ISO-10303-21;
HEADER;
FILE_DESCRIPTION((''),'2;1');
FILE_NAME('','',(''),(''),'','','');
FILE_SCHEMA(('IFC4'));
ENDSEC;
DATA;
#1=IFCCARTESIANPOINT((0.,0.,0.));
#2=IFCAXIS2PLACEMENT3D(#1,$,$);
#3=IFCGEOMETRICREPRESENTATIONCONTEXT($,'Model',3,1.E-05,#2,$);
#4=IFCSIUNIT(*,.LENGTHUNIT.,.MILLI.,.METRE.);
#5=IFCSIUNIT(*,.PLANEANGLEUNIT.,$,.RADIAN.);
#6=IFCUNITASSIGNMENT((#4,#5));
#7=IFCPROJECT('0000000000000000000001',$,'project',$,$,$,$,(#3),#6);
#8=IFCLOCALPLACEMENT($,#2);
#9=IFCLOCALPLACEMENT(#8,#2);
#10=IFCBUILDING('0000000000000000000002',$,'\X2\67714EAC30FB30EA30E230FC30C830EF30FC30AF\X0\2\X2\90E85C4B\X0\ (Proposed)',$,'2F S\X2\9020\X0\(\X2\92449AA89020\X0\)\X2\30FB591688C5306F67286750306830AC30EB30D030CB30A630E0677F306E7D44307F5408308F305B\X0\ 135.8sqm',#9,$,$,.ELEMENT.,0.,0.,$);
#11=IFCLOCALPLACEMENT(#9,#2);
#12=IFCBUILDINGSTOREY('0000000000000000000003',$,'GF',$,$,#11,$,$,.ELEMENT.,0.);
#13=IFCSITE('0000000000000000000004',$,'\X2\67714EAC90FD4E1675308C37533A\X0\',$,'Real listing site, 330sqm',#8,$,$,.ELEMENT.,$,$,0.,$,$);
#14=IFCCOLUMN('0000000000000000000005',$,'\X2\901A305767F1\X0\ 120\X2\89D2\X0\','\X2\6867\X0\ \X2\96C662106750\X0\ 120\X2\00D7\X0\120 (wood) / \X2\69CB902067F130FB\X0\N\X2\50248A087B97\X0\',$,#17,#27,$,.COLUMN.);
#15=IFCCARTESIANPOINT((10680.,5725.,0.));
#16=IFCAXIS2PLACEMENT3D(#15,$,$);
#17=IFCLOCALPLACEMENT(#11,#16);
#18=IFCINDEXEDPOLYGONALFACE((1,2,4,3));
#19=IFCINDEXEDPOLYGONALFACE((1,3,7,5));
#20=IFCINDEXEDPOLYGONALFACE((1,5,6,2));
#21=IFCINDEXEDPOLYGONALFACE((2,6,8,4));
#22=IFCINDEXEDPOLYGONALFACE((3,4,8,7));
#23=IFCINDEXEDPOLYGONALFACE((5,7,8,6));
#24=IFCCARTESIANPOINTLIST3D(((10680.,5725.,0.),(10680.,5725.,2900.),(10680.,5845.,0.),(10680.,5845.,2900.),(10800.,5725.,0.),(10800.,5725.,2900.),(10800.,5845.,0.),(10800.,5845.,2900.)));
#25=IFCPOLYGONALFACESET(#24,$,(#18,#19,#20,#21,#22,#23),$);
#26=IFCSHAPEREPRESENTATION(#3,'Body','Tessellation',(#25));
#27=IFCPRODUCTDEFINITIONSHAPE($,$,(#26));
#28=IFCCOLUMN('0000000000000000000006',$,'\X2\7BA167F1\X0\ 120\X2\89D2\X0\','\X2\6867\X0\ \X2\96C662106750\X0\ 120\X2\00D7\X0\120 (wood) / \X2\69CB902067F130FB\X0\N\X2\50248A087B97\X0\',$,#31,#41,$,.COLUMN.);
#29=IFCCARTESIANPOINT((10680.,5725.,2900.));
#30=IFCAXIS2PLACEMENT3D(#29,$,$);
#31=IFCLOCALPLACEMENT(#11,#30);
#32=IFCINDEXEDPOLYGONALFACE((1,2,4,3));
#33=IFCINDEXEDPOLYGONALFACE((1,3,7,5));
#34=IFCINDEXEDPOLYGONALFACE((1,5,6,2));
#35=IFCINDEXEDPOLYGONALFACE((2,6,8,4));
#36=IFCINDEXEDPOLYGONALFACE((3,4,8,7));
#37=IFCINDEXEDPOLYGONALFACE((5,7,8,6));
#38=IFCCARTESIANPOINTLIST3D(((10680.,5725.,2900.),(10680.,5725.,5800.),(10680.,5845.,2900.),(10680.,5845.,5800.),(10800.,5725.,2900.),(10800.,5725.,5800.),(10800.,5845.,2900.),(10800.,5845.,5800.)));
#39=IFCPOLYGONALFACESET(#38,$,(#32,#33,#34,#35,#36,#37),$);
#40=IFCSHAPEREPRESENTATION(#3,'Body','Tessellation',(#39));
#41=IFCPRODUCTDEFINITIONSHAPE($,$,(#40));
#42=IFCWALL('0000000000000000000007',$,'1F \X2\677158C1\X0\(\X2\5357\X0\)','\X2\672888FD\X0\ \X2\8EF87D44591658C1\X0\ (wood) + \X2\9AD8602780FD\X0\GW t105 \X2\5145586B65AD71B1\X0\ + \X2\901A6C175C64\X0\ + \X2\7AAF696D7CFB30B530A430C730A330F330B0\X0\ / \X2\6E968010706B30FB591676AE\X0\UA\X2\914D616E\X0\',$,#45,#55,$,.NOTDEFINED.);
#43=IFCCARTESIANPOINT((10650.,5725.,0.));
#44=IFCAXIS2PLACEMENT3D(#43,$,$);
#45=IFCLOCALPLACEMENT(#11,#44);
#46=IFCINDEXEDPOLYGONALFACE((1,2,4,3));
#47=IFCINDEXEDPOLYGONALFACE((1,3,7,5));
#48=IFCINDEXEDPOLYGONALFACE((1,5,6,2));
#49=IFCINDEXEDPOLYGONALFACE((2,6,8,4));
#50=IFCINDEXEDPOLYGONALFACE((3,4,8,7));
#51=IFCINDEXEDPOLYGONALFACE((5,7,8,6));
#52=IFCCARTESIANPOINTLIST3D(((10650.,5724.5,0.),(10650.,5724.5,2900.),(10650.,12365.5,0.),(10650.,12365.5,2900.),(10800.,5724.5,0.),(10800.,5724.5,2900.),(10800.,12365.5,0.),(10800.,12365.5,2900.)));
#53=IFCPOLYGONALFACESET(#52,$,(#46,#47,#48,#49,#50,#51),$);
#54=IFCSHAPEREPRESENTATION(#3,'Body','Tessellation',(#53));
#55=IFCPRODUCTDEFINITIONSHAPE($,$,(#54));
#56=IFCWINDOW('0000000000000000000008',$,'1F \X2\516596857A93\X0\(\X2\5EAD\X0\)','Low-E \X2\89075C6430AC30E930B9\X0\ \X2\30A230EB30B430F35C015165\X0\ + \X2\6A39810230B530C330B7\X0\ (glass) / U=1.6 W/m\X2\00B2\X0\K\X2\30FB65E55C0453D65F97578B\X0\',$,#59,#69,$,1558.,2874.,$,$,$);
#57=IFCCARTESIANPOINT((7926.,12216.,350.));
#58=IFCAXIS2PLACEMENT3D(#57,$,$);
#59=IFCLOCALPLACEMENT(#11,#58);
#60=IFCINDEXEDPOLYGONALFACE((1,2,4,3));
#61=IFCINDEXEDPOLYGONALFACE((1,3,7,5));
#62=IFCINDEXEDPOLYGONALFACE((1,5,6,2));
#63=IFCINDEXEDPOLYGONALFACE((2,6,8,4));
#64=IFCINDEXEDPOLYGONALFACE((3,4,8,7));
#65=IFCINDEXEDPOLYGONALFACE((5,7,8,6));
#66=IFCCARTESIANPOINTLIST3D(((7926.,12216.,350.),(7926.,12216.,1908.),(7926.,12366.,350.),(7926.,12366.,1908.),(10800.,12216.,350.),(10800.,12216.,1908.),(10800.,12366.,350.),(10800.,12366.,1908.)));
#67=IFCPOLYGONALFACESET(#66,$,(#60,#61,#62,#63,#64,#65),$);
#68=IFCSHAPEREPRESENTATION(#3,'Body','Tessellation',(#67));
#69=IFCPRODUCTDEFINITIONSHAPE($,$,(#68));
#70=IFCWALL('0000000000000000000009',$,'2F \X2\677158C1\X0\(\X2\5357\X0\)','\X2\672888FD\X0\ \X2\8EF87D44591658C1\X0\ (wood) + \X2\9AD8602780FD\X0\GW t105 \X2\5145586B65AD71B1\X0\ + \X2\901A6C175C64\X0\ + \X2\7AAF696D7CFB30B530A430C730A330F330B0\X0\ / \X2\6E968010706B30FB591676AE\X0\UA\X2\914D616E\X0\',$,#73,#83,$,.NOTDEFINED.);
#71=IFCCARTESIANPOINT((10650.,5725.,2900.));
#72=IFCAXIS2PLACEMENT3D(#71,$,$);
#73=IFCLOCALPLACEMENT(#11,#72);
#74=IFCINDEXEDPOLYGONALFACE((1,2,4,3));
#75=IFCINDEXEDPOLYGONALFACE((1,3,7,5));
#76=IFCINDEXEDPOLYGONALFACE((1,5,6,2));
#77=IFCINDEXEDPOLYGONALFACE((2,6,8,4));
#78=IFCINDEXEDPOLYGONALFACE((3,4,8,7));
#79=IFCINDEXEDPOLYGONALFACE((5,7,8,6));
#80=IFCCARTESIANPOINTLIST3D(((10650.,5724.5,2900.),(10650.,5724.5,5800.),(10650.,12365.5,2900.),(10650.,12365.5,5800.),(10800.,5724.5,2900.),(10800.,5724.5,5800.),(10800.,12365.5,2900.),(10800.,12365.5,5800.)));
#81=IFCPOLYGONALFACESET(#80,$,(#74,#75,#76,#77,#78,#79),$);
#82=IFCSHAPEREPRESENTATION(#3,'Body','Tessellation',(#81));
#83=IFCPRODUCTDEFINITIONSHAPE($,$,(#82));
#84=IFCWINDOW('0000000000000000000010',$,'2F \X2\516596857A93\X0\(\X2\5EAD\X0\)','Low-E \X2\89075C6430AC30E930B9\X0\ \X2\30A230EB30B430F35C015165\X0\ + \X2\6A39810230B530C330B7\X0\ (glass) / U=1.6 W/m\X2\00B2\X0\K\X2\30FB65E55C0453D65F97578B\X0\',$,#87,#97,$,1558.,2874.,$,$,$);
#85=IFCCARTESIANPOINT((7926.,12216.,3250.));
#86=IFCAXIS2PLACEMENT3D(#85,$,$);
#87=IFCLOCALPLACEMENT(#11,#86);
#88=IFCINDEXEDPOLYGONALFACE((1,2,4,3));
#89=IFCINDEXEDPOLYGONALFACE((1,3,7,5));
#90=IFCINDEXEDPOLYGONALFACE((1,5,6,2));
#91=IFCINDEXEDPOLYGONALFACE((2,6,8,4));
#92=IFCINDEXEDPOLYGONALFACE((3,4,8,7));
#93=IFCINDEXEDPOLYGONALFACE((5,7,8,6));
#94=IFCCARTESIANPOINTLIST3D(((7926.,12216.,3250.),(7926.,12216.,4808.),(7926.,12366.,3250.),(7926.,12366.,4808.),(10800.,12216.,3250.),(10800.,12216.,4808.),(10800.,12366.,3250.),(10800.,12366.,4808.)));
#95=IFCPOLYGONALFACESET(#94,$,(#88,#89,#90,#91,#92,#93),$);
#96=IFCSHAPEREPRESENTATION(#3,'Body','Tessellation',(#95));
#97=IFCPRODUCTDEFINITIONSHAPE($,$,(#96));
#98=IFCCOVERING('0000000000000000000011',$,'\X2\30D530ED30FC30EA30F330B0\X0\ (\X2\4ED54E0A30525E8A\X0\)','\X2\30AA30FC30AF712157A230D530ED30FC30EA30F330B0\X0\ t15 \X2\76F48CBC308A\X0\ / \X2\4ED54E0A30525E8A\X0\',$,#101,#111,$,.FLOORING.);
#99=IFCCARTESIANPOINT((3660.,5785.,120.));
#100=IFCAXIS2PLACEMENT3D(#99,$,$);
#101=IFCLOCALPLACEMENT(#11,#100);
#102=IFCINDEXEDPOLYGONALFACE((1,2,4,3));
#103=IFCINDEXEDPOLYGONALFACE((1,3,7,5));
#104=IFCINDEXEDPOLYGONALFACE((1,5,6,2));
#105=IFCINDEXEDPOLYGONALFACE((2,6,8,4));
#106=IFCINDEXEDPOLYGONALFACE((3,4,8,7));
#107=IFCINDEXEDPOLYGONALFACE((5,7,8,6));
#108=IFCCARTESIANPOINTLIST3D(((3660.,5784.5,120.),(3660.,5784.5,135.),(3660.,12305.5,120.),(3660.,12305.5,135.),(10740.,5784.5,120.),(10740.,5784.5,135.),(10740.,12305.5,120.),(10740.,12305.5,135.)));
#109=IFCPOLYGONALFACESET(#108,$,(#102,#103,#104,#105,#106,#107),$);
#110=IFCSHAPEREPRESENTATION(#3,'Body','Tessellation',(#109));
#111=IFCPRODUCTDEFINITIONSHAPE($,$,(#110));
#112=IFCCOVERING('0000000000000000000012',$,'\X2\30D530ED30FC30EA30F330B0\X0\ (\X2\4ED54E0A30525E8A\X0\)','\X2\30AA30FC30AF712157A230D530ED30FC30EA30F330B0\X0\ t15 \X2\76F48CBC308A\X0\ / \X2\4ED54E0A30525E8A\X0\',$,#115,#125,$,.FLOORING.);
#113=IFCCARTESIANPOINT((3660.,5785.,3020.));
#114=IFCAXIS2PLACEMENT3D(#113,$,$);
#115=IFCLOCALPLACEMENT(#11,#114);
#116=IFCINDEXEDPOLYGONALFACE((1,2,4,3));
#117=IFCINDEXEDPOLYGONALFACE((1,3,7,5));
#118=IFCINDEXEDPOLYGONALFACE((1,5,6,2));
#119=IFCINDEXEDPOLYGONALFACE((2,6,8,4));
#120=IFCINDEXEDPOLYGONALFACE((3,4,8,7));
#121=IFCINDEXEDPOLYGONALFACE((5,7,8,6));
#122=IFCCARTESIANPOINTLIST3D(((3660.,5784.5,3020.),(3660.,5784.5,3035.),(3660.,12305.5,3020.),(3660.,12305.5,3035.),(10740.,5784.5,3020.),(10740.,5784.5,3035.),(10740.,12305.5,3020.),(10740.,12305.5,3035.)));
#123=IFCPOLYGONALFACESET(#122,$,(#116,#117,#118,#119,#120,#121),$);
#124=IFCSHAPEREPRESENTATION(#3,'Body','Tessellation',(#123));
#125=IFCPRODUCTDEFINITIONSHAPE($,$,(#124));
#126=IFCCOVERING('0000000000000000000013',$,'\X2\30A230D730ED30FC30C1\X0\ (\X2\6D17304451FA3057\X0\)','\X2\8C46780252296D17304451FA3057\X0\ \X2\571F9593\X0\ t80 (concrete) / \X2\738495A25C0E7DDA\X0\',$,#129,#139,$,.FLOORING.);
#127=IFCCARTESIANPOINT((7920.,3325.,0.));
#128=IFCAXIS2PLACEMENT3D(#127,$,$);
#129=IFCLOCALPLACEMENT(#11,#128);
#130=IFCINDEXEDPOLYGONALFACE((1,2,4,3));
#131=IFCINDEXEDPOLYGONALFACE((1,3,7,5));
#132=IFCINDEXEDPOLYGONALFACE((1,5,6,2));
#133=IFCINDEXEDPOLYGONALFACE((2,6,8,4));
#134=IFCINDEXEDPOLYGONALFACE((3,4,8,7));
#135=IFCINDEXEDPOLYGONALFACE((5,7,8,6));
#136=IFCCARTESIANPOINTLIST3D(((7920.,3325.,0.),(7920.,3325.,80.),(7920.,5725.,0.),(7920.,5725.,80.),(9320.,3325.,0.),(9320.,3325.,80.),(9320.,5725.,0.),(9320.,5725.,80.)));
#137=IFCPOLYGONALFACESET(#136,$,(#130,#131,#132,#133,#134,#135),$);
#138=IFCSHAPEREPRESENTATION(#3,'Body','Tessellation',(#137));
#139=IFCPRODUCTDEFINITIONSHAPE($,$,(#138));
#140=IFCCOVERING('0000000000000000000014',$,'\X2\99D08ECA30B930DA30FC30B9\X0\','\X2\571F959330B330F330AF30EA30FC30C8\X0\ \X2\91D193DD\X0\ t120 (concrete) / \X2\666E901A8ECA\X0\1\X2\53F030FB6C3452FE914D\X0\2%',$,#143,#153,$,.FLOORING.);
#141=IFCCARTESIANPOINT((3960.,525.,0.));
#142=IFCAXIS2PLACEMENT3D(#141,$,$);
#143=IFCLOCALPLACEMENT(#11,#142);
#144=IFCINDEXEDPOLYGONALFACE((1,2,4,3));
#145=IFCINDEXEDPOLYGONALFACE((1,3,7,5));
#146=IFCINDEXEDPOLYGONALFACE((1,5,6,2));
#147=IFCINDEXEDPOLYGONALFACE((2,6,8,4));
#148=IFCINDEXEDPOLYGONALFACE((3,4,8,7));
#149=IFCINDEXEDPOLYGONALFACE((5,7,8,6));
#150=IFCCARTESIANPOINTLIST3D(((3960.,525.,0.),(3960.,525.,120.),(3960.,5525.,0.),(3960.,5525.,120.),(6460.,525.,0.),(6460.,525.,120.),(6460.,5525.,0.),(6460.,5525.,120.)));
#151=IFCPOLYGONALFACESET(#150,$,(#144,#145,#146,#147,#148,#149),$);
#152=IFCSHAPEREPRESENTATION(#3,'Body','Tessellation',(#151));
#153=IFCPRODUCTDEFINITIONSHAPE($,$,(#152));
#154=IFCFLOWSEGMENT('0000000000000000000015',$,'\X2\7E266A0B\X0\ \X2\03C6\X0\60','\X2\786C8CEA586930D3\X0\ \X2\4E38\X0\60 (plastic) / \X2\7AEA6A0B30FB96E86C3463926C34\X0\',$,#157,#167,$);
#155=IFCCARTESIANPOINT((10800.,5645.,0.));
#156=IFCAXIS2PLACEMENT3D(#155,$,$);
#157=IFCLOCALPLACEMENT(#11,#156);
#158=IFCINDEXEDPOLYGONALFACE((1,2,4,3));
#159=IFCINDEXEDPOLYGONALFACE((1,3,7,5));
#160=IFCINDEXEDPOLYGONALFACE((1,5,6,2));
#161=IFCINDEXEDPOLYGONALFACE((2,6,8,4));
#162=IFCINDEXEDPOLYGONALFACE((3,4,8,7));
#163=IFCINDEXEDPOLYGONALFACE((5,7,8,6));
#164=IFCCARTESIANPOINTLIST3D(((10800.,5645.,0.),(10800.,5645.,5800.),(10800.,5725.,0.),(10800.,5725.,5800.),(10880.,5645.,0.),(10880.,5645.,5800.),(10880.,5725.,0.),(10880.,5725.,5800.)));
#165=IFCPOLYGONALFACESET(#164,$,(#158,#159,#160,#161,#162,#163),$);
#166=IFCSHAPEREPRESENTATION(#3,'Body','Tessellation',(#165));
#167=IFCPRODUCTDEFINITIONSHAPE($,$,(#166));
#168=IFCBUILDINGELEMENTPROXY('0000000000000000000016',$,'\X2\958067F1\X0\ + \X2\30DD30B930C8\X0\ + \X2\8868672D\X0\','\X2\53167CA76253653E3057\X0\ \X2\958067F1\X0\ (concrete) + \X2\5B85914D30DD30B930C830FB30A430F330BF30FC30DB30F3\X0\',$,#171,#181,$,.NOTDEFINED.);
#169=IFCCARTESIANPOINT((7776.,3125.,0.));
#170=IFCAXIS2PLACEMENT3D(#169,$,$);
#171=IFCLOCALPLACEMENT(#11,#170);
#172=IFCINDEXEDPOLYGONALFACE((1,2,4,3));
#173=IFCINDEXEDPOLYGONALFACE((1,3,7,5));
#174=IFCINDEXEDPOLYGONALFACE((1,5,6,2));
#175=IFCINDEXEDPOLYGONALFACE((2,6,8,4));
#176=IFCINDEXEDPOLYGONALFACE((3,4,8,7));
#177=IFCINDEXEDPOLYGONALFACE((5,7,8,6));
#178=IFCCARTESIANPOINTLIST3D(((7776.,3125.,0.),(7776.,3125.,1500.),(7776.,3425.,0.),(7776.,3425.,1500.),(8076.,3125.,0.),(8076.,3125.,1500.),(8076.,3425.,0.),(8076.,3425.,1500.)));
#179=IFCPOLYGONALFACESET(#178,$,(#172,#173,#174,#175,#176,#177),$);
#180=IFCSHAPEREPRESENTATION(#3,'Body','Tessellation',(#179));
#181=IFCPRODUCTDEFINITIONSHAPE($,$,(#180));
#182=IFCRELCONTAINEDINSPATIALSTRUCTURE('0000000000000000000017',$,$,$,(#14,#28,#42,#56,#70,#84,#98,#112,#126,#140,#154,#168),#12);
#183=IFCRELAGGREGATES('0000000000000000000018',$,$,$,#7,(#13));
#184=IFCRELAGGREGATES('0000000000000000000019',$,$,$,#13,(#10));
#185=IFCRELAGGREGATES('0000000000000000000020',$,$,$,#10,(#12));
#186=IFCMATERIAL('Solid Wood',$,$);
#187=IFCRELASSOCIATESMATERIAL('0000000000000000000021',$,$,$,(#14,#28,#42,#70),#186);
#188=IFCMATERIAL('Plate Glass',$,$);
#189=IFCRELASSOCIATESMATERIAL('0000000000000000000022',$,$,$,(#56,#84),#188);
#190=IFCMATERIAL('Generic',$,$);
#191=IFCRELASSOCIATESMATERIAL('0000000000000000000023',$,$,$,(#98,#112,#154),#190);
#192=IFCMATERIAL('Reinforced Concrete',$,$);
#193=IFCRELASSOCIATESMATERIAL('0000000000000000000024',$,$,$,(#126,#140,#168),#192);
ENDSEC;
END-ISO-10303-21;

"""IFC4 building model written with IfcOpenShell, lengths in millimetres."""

from ifc_helpers import new_model, si_unit, frame, frame_2d, origin, place, context, project, spatial, rectangle, extrude, material, element, fill, save


model = new_model("IFC4")

# Units and contexts
model_context = context("Model", 3, precision=1e-05, world=origin())
ifc_project = project(units=[si_unit("LENGTHUNIT", "METRE", prefix="MILLI"), si_unit("PLANEANGLEUNIT", "RADIAN")], contexts=[model_context])

# Site, building, storey
site_placement = place(None, origin())
site = spatial("IfcSite", under=ifc_project, at=site_placement, Name="東京都世田谷区", ObjectType="Real listing site, 330sqm", CompositionType="ELEMENT", RefElevation=0.0)
building_placement = place(site_placement, origin())
building = spatial("IfcBuilding", under=site, at=building_placement, Name="東京・リモートワーク2部屋 (Proposed)", ObjectType="2F S造(鉄骨造)・外装は木材とガルバニウム板の組み合わせ 135.8sqm", CompositionType="ELEMENT", ElevationOfRefHeight=0.0, ElevationOfTerrain=0.0)
storey_placement = place(building_placement, origin())
storey = spatial("IfcBuildingStorey", under=building, at=storey_placement, Name="GF", CompositionType="ELEMENT", Elevation=0.0)

# Columns
ifc_material_1 = material(Name="Solid Wood")
column_1_placement = place(storey_placement, frame((10680.0, 5725.0, 0.0)))
element("IfcColumn", 1, at=column_1_placement, inside=storey, material=ifc_material_1, Name="通し柱 120角", Description="桧 集成材 120×120 (wood) / 構造柱・N値計算", PredefinedType="COLUMN", context=model_context, shape_type="SweptSolid", body=[
    extrude(rectangle(XDim=120.0, YDim=120.0, at=frame_2d((60.0, 60.0))), frame((10680.0, 5725.0, 0.0)), (0.0, 0.0, 1.0), 2900.0),
])
column_2_placement = place(storey_placement, frame((10680.0, 5725.0, 2900.0)))
element("IfcColumn", 2, at=column_2_placement, inside=storey, material=ifc_material_1, Name="管柱 120角", Description="桧 集成材 120×120 (wood) / 構造柱・N値計算", PredefinedType="COLUMN", context=model_context, shape_type="SweptSolid", body=[
    extrude(rectangle(XDim=120.0, YDim=120.0, at=frame_2d((60.0, 60.0))), frame((10680.0, 5725.0, 2900.0)), (0.0, 0.0, 1.0), 2900.0),
])

# Wall, opening, window
wall_1_placement = place(storey_placement, frame((10650.0, 5725.0, 0.0)))
wall_1 = element("IfcWall", 3, at=wall_1_placement, inside=storey, material=ifc_material_1, Name="1F 東壁(南)", Description="木製 軸組外壁 (wood) + 高性能GW t105 充填断熱 + 通気層 + 窯業系サイディング / 準耐火・外皮UA配慮", PredefinedType="NOTDEFINED", context=model_context, shape_type="SweptSolid", body=[
    extrude(rectangle(XDim=150.0, YDim=6641.0, at=frame_2d((75.0, 3320.0))), frame((10650.0, 5725.0, 0.0)), (0.0, 0.0, 1.0), 2900.0),
])
opening_1_placement = place(storey_placement, frame((7926.0, 12216.0, 350.0)))
opening_1 = element("IfcOpeningElement", 4, at=opening_1_placement, cuts=wall_1, PredefinedType="NOTDEFINED", context=model_context, shape_type="SweptSolid", body=[
    extrude(rectangle(XDim=2874.0, YDim=150.0, at=frame_2d((1437.0, 75.0))), frame((7926.0, 12216.0, 350.0)), (0.0, 0.0, 1.0), 1558.0),
])
ifc_material_2 = material(Name="Plate Glass")
window_1_placement = place(storey_placement, frame((7926.0, 12216.0, 350.0)))
window_1 = element("IfcWindow", 5, at=window_1_placement, inside=storey, material=ifc_material_2, Name="1F 入隅窓(庭)", Description="Low-E 複層ガラス アルゴン封入 + 樹脂サッシ (glass) / U=1.6 W/m²K・日射取得型", OverallHeight=1558.0, OverallWidth=2874.0, context=model_context, shape_type="SweptSolid", body=[
    extrude(rectangle(XDim=2874.0, YDim=150.0, at=frame_2d((1437.0, 75.0))), frame((7926.0, 12216.0, 350.0)), (0.0, 0.0, 1.0), 1558.0),
])
fill(opening_1, window_1)

# Wall, opening, window
wall_2_placement = place(storey_placement, frame((10650.0, 5725.0, 2900.0)))
wall_2 = element("IfcWall", 6, at=wall_2_placement, inside=storey, material=ifc_material_1, Name="2F 東壁(南)", Description="木製 軸組外壁 (wood) + 高性能GW t105 充填断熱 + 通気層 + 窯業系サイディング / 準耐火・外皮UA配慮", PredefinedType="NOTDEFINED", context=model_context, shape_type="SweptSolid", body=[
    extrude(rectangle(XDim=150.0, YDim=6641.0, at=frame_2d((75.0, 3320.0))), frame((10650.0, 5725.0, 2900.0)), (0.0, 0.0, 1.0), 2900.0),
])
opening_2_placement = place(storey_placement, frame((7926.0, 12216.0, 3250.0)))
opening_2 = element("IfcOpeningElement", 7, at=opening_2_placement, cuts=wall_2, PredefinedType="NOTDEFINED", context=model_context, shape_type="SweptSolid", body=[
    extrude(rectangle(XDim=2874.0, YDim=150.0, at=frame_2d((1437.0, 75.0))), frame((7926.0, 12216.0, 3250.0)), (0.0, 0.0, 1.0), 1558.0),
])
window_2_placement = place(storey_placement, frame((7926.0, 12216.0, 3250.0)))
window_2 = element("IfcWindow", 8, at=window_2_placement, inside=storey, material=ifc_material_2, Name="2F 入隅窓(庭)", Description="Low-E 複層ガラス アルゴン封入 + 樹脂サッシ (glass) / U=1.6 W/m²K・日射取得型", OverallHeight=1558.0, OverallWidth=2874.0, context=model_context, shape_type="SweptSolid", body=[
    extrude(rectangle(XDim=2874.0, YDim=150.0, at=frame_2d((1437.0, 75.0))), frame((7926.0, 12216.0, 3250.0)), (0.0, 0.0, 1.0), 1558.0),
])
fill(opening_2, window_2)

# Coverings
ifc_material_3 = material(Name="Generic")
covering_1_placement = place(storey_placement, frame((3660.0, 5785.0, 120.0)))
element("IfcCovering", 9, at=covering_1_placement, inside=storey, material=ifc_material_3, Name="フローリング (仕上げ床)", Description="オーク無垢フローリング t15 直貼り / 仕上げ床", PredefinedType="FLOORING", context=model_context, shape_type="SweptSolid", body=[
    extrude(rectangle(XDim=7080.0, YDim=6521.0, at=frame_2d((3540.0, 3260.0))), frame((3660.0, 5785.0, 120.0)), (0.0, 0.0, 1.0), 15.0),
])
covering_2_placement = place(storey_placement, frame((3660.0, 5785.0, 3020.0)))
element("IfcCovering", 10, at=covering_2_placement, inside=storey, material=ifc_material_3, Name="フローリング (仕上げ床)", Description="オーク無垢フローリング t15 直貼り / 仕上げ床", PredefinedType="FLOORING", context=model_context, shape_type="SweptSolid", body=[
    extrude(rectangle(XDim=7080.0, YDim=6521.0, at=frame_2d((3540.0, 3260.0))), frame((3660.0, 5785.0, 3020.0)), (0.0, 0.0, 1.0), 15.0),
])
ifc_material_4 = material(Name="Reinforced Concrete")
covering_3_placement = place(storey_placement, frame((7920.0, 3325.0, 0.0)))
element("IfcCovering", 11, at=covering_3_placement, inside=storey, material=ifc_material_4, Name="アプローチ (洗い出し)", Description="豆砂利洗い出し 土間 t80 (concrete) / 玄関導線", PredefinedType="FLOORING", context=model_context, shape_type="SweptSolid", body=[
    extrude(rectangle(XDim=1400.0, YDim=2400.0, at=frame_2d((700.0, 1200.0))), frame((7920.0, 3325.0, 0.0)), (0.0, 0.0, 1.0), 80.0),
])
covering_4_placement = place(storey_placement, frame((3960.0, 525.0, 0.0)))
element("IfcCovering", 12, at=covering_4_placement, inside=storey, material=ifc_material_4, Name="駐車スペース", Description="土間コンクリート 金鏝 t120 (concrete) / 普通車1台・水勾配2%", PredefinedType="FLOORING", context=model_context, shape_type="SweptSolid", body=[
    extrude(rectangle(XDim=2500.0, YDim=5000.0, at=frame_2d((1250.0, 2500.0))), frame((3960.0, 525.0, 0.0)), (0.0, 0.0, 1.0), 120.0),
])

# Flow segment
flow_segment_placement = place(storey_placement, frame((10800.0, 5645.0, 0.0)))
element("IfcFlowSegment", 13, at=flow_segment_placement, inside=storey, material=ifc_material_3, Name="縦樋 φ60", Description="硬質塩ビ 丸60 (plastic) / 竪樋・雨水排水", context=model_context, shape_type="SweptSolid", body=[
    extrude(rectangle(XDim=80.0, YDim=80.0, at=frame_2d((40.0, 40.0))), frame((10800.0, 5645.0, 0.0)), (0.0, 0.0, 1.0), 5800.0),
])

# Building element proxy
proxy_placement = place(storey_placement, frame((7776.0, 3125.0, 0.0)))
element("IfcBuildingElementProxy", 14, at=proxy_placement, inside=storey, material=ifc_material_4, Name="門柱 + ポスト + 表札", Description="化粧打放し 門柱 (concrete) + 宅配ポスト・インターホン", PredefinedType="NOTDEFINED", context=model_context, shape_type="SweptSolid", body=[
    extrude(rectangle(XDim=300.0, YDim=300.0, at=frame_2d((150.0, 150.0))), frame((7776.0, 3125.0, 0.0)), (0.0, 0.0, 1.0), 1500.0),
])

save(model, "model.ifc")
